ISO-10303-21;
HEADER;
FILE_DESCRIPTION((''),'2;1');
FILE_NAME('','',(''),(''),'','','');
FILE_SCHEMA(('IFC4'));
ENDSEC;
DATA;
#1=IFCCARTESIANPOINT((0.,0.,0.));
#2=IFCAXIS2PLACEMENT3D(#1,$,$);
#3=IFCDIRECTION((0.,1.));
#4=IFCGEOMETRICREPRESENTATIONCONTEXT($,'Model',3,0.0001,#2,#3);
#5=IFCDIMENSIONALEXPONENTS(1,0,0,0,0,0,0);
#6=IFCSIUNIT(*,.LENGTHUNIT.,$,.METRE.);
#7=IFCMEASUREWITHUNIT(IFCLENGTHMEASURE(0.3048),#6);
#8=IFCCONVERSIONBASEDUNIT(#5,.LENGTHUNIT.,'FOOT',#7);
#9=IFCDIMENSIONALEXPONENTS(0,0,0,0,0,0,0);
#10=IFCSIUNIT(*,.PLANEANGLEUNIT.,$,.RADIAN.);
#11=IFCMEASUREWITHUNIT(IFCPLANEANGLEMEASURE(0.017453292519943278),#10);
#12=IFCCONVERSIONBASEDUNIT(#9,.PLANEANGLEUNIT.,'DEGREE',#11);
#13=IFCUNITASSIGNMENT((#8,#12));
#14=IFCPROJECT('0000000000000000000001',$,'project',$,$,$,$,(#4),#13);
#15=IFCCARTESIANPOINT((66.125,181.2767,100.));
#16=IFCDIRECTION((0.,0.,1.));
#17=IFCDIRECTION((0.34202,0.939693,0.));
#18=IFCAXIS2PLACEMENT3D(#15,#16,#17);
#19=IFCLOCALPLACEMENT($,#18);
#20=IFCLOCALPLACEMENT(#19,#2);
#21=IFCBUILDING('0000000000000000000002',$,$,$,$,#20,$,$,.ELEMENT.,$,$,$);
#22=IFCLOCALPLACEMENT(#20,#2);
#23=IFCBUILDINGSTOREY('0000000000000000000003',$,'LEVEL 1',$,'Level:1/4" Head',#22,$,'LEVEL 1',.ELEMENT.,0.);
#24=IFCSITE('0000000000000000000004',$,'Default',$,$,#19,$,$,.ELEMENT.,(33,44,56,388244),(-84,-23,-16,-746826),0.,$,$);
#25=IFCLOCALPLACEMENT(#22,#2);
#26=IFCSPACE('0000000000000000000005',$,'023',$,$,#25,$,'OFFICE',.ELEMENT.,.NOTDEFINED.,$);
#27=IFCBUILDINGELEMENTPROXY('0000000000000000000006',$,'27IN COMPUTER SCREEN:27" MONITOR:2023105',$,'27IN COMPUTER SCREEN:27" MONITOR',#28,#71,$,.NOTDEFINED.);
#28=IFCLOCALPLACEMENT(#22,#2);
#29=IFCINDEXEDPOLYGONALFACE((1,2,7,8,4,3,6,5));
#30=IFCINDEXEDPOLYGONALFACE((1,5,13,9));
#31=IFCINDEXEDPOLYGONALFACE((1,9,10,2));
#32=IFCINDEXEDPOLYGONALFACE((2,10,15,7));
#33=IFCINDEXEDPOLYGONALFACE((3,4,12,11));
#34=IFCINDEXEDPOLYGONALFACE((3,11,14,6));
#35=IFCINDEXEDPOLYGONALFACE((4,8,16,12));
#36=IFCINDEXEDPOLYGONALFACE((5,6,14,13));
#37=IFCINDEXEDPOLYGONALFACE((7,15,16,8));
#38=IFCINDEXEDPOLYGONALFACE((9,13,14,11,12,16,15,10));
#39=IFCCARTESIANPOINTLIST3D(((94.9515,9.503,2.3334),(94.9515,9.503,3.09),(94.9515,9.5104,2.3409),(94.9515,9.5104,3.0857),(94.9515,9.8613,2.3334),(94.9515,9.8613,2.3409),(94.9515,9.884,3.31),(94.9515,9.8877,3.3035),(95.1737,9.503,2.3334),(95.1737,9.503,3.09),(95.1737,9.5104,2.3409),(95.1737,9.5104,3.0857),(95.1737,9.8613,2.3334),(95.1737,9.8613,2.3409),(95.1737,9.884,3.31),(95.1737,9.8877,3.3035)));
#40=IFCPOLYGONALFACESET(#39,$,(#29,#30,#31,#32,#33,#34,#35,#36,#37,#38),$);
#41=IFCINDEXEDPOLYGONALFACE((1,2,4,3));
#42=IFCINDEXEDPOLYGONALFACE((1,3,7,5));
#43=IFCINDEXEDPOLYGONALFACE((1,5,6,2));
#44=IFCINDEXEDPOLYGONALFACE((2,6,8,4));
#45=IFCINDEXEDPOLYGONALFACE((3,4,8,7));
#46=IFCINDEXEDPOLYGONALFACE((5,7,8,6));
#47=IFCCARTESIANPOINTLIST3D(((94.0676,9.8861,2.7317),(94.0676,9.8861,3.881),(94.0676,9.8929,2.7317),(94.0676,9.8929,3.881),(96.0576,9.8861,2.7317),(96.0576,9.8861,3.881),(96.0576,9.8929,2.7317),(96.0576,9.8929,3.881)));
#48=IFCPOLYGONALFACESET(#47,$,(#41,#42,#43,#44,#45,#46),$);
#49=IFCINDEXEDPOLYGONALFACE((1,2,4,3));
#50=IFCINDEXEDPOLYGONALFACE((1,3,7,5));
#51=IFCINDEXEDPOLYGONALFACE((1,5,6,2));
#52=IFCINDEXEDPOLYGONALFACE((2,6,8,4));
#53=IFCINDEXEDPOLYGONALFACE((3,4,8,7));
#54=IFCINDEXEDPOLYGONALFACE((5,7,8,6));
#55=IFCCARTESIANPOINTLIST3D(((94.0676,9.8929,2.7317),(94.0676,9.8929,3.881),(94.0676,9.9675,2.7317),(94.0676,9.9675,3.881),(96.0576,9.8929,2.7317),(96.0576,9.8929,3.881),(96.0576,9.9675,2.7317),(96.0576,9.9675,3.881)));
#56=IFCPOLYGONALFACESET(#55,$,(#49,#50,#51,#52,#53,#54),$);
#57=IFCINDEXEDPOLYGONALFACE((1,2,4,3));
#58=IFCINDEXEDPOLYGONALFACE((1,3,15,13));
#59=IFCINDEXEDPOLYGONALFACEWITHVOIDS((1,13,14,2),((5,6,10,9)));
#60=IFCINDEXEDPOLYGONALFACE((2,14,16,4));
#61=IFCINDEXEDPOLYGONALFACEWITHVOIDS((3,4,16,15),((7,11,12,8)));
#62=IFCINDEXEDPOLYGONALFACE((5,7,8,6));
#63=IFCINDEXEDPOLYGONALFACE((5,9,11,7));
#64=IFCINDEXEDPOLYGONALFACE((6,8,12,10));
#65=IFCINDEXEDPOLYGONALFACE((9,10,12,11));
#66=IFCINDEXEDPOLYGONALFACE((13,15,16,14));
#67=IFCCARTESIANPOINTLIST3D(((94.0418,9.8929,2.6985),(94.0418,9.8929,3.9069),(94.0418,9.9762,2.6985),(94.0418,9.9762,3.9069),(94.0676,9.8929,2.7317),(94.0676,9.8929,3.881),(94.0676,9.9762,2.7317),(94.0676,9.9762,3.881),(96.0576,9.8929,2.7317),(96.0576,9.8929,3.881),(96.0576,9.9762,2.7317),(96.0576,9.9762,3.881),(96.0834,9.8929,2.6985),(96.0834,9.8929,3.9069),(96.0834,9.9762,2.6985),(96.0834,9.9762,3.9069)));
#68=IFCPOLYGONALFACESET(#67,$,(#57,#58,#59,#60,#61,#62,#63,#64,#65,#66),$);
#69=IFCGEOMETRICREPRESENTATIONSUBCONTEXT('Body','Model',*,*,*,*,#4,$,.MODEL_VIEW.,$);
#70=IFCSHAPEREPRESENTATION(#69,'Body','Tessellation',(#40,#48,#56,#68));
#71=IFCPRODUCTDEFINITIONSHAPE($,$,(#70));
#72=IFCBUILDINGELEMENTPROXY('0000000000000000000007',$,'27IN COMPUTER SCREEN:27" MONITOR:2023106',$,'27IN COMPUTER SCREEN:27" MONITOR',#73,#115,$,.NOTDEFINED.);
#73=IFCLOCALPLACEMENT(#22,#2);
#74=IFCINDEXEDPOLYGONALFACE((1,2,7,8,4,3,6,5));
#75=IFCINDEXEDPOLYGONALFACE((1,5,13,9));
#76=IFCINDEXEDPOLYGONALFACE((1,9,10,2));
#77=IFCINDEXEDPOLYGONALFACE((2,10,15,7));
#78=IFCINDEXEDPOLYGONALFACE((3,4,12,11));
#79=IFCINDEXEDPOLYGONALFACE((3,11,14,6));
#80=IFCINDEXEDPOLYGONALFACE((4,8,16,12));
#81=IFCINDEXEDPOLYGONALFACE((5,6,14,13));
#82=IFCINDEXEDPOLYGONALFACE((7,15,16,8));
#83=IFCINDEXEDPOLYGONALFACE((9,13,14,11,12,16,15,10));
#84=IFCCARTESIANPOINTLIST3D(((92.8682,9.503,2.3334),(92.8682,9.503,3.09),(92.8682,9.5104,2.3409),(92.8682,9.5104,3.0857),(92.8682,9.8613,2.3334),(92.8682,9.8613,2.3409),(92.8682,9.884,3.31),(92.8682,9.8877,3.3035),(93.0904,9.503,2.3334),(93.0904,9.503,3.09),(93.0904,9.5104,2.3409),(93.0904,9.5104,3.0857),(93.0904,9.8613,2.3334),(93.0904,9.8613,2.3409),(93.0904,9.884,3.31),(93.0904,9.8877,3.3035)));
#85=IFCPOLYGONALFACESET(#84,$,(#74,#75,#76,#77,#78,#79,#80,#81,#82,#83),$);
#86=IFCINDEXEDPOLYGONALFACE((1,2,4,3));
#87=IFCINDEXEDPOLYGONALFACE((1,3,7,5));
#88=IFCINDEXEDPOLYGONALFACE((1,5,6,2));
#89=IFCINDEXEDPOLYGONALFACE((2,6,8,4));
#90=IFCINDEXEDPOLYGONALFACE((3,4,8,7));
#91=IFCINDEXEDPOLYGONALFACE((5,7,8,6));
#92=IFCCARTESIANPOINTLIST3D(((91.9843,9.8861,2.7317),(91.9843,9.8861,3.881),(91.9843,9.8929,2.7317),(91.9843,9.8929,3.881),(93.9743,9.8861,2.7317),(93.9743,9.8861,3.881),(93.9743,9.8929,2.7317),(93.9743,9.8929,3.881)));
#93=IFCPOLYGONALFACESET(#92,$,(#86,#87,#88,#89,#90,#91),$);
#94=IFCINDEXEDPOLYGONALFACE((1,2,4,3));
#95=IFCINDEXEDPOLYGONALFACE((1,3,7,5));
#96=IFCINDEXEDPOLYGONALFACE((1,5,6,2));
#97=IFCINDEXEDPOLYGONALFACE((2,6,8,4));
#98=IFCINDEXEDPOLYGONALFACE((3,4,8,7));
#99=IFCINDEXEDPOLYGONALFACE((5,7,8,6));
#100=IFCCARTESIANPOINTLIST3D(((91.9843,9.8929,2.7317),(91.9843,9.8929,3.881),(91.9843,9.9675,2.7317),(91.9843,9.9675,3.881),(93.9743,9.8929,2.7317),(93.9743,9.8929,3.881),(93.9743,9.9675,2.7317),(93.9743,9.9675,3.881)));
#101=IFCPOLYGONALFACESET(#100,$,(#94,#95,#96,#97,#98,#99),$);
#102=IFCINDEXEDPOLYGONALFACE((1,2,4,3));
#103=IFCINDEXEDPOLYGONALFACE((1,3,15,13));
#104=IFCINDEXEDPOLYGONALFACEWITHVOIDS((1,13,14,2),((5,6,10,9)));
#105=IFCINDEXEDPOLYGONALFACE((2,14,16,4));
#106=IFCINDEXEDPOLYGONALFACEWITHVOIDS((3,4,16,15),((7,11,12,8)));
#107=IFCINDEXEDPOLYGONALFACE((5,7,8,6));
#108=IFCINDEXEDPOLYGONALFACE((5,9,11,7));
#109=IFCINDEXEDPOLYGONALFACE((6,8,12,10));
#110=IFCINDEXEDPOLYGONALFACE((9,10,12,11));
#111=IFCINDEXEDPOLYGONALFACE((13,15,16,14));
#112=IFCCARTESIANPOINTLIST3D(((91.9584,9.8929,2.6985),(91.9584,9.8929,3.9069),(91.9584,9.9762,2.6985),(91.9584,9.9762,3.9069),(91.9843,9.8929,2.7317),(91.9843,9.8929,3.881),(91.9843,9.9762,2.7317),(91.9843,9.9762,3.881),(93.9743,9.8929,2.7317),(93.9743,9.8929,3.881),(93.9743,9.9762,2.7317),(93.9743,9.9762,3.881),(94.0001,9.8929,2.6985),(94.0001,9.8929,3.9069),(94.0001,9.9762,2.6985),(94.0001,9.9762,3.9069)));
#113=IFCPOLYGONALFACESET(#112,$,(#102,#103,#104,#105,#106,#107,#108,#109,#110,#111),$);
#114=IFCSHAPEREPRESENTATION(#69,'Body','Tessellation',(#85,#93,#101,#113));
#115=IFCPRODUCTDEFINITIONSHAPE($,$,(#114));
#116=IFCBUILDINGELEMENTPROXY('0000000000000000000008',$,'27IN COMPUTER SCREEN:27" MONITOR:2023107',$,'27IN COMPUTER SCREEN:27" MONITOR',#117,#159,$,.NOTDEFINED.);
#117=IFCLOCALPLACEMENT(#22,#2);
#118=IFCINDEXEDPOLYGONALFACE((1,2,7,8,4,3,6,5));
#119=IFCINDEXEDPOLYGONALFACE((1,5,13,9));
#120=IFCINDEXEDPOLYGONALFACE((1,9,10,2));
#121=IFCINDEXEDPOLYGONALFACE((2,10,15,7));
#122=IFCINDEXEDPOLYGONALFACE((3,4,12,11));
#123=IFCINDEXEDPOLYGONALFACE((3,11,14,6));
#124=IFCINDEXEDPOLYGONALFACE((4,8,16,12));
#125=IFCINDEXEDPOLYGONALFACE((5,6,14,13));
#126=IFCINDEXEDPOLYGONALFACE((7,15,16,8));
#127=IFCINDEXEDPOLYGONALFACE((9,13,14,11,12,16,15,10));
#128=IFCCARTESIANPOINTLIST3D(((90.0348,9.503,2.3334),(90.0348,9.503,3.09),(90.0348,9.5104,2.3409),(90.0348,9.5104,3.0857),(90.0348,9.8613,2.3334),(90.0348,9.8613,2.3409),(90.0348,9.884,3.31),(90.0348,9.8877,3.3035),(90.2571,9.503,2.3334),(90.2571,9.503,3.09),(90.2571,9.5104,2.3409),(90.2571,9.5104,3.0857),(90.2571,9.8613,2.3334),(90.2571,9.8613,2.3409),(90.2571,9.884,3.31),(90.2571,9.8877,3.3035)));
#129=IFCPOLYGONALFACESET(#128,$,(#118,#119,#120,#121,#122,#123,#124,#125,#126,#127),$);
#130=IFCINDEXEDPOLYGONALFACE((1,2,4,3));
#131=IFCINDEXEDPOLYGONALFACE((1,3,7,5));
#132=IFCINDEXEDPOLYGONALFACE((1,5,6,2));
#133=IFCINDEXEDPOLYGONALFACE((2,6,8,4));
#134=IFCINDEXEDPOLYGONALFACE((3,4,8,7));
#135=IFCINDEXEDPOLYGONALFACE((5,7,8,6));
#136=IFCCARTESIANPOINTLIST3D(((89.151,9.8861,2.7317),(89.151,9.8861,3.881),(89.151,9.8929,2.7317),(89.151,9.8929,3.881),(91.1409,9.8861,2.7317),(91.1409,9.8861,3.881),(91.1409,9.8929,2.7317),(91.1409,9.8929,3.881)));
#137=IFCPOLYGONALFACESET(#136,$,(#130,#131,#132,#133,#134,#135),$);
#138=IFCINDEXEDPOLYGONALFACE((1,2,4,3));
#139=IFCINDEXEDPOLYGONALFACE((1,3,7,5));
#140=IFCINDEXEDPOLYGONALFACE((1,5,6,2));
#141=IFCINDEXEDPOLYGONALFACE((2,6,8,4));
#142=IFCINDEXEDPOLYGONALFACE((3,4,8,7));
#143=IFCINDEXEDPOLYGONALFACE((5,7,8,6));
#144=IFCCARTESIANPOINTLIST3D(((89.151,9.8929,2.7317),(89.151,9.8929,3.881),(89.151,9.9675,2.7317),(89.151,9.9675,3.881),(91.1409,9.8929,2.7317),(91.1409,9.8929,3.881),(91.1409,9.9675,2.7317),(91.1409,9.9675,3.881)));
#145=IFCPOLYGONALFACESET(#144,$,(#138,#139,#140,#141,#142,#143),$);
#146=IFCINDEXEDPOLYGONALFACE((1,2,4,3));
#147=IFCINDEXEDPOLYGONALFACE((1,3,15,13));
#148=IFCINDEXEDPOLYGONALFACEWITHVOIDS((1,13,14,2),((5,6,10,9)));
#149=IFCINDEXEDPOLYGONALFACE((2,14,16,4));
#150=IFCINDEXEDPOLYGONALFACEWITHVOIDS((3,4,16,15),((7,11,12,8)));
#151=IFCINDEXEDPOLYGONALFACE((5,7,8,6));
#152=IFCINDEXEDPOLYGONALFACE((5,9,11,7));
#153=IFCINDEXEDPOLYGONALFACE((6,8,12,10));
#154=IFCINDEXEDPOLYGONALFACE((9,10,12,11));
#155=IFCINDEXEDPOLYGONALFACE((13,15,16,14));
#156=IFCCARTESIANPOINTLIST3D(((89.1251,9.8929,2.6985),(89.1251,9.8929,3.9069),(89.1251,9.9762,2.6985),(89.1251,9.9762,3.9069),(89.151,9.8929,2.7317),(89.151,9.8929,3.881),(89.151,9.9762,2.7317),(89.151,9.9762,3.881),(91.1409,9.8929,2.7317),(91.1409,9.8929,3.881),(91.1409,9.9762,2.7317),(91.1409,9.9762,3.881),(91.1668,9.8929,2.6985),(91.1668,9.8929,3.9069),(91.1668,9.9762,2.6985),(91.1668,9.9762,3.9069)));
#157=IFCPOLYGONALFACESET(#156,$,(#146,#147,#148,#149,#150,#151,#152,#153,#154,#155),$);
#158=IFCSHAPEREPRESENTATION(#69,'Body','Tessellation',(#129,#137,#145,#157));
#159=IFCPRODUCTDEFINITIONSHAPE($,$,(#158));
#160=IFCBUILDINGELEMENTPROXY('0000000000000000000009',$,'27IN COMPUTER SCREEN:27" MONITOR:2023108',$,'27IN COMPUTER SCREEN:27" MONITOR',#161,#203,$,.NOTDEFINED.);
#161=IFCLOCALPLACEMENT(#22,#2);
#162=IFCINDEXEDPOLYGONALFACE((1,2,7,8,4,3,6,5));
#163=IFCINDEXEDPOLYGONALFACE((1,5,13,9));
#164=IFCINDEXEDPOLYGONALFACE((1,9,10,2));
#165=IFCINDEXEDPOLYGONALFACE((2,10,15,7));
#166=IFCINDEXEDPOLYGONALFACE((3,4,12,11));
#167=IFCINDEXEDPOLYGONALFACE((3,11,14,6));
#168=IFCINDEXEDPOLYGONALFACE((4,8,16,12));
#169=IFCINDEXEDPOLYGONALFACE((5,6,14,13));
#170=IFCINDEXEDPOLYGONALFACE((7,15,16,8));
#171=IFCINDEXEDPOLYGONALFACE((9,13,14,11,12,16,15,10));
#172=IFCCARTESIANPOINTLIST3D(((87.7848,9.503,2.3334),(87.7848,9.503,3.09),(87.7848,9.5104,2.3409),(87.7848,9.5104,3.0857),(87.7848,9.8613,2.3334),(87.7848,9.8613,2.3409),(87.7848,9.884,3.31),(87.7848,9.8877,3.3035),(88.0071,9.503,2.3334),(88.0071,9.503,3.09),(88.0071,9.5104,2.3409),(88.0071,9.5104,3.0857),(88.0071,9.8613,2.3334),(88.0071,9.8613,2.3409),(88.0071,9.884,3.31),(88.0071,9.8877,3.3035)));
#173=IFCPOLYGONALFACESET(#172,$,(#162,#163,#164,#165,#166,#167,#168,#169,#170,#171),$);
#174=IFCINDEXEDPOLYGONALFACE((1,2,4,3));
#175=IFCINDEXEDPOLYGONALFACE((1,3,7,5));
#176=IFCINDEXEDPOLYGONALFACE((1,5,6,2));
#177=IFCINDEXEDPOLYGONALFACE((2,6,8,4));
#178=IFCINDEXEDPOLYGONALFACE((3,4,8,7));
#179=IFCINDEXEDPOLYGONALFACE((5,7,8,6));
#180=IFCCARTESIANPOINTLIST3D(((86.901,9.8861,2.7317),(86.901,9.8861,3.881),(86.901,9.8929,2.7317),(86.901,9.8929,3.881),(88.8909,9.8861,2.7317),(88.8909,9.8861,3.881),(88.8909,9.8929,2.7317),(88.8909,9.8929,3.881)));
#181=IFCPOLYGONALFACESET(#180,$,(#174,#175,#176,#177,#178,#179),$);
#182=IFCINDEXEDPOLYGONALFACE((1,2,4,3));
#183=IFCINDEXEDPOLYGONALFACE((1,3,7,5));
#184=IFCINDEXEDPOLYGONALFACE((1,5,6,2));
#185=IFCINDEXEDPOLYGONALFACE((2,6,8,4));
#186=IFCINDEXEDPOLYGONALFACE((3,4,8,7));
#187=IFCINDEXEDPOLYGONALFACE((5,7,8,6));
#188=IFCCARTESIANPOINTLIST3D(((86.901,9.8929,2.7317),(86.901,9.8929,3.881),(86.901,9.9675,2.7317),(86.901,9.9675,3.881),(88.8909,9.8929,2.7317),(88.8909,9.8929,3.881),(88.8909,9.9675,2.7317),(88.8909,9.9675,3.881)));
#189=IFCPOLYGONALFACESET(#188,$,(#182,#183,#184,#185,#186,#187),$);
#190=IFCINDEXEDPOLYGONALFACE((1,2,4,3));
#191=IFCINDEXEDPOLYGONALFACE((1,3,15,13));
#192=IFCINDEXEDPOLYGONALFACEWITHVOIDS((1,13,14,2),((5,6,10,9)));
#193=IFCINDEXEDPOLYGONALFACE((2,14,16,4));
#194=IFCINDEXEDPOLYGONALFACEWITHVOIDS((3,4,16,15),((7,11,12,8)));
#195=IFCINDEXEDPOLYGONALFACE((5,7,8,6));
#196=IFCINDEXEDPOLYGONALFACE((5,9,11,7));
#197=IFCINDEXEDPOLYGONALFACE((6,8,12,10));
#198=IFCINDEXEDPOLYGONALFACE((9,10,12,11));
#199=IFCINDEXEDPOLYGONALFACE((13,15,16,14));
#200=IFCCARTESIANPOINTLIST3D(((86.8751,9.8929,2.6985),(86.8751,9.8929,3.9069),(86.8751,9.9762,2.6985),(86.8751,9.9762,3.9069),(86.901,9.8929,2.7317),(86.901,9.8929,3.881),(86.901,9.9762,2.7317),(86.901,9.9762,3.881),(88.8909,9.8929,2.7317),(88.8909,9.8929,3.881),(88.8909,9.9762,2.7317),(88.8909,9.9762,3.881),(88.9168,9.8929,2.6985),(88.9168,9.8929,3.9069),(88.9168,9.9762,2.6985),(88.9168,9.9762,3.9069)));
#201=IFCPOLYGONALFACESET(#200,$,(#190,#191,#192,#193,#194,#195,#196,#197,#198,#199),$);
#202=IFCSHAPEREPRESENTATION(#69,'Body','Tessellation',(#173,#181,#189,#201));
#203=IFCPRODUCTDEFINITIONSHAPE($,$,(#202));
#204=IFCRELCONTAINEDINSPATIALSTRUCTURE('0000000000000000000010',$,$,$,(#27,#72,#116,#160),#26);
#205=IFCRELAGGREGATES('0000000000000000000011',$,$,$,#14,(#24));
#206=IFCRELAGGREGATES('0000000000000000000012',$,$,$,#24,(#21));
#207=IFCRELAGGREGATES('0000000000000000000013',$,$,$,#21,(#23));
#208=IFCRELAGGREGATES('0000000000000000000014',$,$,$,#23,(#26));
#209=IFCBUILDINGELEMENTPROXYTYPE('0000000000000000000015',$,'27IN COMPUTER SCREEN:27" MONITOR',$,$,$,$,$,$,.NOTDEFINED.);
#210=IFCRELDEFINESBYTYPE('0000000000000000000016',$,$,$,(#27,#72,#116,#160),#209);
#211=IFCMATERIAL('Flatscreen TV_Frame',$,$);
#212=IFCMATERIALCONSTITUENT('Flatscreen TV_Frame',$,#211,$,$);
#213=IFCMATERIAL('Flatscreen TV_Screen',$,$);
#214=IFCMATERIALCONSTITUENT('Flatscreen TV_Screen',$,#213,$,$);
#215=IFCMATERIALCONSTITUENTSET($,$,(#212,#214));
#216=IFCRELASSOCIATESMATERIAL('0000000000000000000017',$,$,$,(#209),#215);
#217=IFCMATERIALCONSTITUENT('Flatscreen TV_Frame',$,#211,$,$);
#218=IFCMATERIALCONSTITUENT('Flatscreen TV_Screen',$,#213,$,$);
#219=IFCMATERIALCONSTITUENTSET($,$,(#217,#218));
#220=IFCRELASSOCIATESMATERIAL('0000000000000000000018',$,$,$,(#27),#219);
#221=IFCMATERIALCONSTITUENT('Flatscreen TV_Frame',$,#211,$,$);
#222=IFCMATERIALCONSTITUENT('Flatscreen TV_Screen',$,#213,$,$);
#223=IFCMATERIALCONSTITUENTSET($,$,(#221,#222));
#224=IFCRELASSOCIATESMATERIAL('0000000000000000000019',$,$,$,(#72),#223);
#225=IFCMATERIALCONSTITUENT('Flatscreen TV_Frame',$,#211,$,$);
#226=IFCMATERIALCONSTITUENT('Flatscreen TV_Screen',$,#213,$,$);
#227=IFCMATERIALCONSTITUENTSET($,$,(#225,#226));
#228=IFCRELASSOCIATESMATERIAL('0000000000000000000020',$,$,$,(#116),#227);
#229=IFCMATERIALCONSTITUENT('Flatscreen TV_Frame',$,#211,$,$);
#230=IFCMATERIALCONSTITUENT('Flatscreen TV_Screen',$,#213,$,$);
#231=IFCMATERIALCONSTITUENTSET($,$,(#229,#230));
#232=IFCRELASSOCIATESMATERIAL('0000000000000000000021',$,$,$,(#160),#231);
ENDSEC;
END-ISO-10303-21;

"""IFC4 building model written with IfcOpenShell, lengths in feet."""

from ifc_helpers import new_model, entity, si_unit, converted_unit, direction, frame, frame_2d, origin, origin_2d_with_axis, place, context, subcontext, project, spatial, polyline, rectangle, outline, extrude, source, transform, mapped, material, constituent, constituent_set, type_object, type_shapes, element, save


model = new_model("IFC4")

# Units and contexts
model_context = context("Model", 3, precision=0.0001, world=origin(), true_north=direction((0.0, 1.0)))
body_context = subcontext(model_context, "Body", "Model", "MODEL_VIEW")
ifc_project = project(units=[converted_unit("LENGTHUNIT", "FOOT", entity("IfcLengthMeasure", 0.3048), si_unit("LENGTHUNIT", "METRE"), dimensions=[1, 0, 0, 0, 0, 0, 0]), converted_unit("PLANEANGLEUNIT", "DEGREE", entity("IfcPlaneAngleMeasure", 0.017453292519943278), si_unit("PLANEANGLEUNIT", "RADIAN"), dimensions=[0, 0, 0, 0, 0, 0, 0])], contexts=[model_context])

# Site, building, storey
site_placement = place(None, frame((66.125, 181.2767, 100.0), z_axis=(0.0, 0.0, 1.0), x_axis=(0.34202, 0.939693, 0.0)))
site = spatial("IfcSite", under=ifc_project, at=site_placement, Name="Default", CompositionType="ELEMENT", RefLatitude=(33, 44, 56, 388244), RefLongitude=(-84, -23, -16, -746826), RefElevation=0.0)
building_placement = place(site_placement, origin())
building = spatial("IfcBuilding", under=site, at=building_placement, CompositionType="ELEMENT")
storey_placement = place(building_placement, origin())
storey = spatial("IfcBuildingStorey", under=building, at=storey_placement, Name="LEVEL 1", ObjectType="Level:1/4\" Head", LongName="LEVEL 1", CompositionType="ELEMENT", Elevation=0.0)

# Shared definitions
space_1_placement = place(storey_placement, origin())
space_1 = spatial("IfcSpace", under=storey, at=space_1_placement, Name="023", LongName="OFFICE", CompositionType="ELEMENT", PredefinedType="NOTDEFINED")

# Building element proxies
ifc_material_1 = material(Name="Flatscreen TV_Frame")
ifc_constituent_1 = constituent(ifc_material_1, Name="Flatscreen TV_Frame")
ifc_material_2 = material(Name="Flatscreen TV_Screen")
ifc_constituent_2 = constituent(ifc_material_2, Name="Flatscreen TV_Screen")
ifc_constituent_set_1 = constituent_set(constituents=[ifc_constituent_1, ifc_constituent_2])
ifc_constituent_3 = constituent(ifc_material_1, Name="Flatscreen TV_Frame")
ifc_constituent_4 = constituent(ifc_material_2, Name="Flatscreen TV_Screen")
ifc_constituent_set_2 = constituent_set(constituents=[ifc_constituent_3, ifc_constituent_4])
building_element_proxy_type_1 = type_object("IfcBuildingElementProxyType", Name="27IN COMPUTER SCREEN:27\" MONITOR", PredefinedType="NOTDEFINED", material=ifc_constituent_set_2)
shared_shape_1 = source(origin(), body_context, "Body", "SweptSolid", [
    extrude(outline(polyline([(-0.4392, -0.3657), (-0.4392, -0.3731), (0.0007, -0.3731), (0.379, 0.2821), (0.0686, 0.4613), (0.0649, 0.4548), (0.3688, 0.2794), (-0.0036, -0.3657), (-0.4392, -0.3657)])), frame((-0.1111, -0.0264, 0.0687), z_axis=(-1.0, 0.0, 0.0), x_axis=(0.0, 0.866025, -0.5)), (0.0, 0.0, -1.0), 0.2222),
    extrude(rectangle(XDim=0.0068, YDim=1.9899, at=origin_2d_with_axis()), frame((0.0, -0.2257, 0.0331), z_axis=(0.0, 0.0, 1.0), x_axis=(0.0, 1.0, 0.0)), (0.0, 0.0, 1.0), 1.1493),
    extrude(rectangle(XDim=0.0746, YDim=1.9899, at=frame_2d((0.0, 0.0), x_axis=(1.0, 0.0))), frame((0.0, -0.2664, 0.0331), z_axis=(0.0, 0.0, 1.0), x_axis=(0.0, 1.0, 0.0)), (0.0, 0.0, 1.0), 1.1493),
    extrude(outline(polyline([(-0.6042, -1.0208), (0.6042, -1.0208), (0.6042, 1.0208), (-0.6042, 1.0208), (-0.6042, -1.0208)]), holes=[polyline([(-0.5783, -0.995), (-0.5783, 0.995), (0.571, 0.995), (0.571, -0.995), (-0.5783, -0.995)])]), frame((0.0, -0.3125, 0.6042), z_axis=(0.0, 1.0, 0.0), x_axis=(0.0, 0.0, -1.0)), (0.0, 0.0, 1.0), 0.0833),
])
type_shapes(building_element_proxy_type_1, [shared_shape_1])
proxy_1_placement = place(space_1_placement, frame((95.0626, 9.6637, 2.6985), z_axis=(0.0, 0.0, 1.0), x_axis=(-1.0, 0.0, 0.0)))
element("IfcBuildingElementProxy", 1, at=proxy_1_placement, inside=space_1, type_object=building_element_proxy_type_1, material=ifc_constituent_set_1, Name="27IN COMPUTER SCREEN:27\" MONITOR:2023105", ObjectType="27IN COMPUTER SCREEN:27\" MONITOR", PredefinedType="NOTDEFINED", context=body_context, shape_type="MappedRepresentation", body=[
    mapped(shared_shape_1, transform((0.0, 0.0, 0.0), scale=1.0)),
])
ifc_constituent_5 = constituent(ifc_material_1, Name="Flatscreen TV_Frame")
ifc_constituent_6 = constituent(ifc_material_2, Name="Flatscreen TV_Screen")
ifc_constituent_set_3 = constituent_set(constituents=[ifc_constituent_5, ifc_constituent_6])
proxy_2_placement = place(space_1_placement, frame((92.9793, 9.6637, 2.6985), z_axis=(0.0, 0.0, 1.0), x_axis=(-1.0, 0.0, 0.0)))
element("IfcBuildingElementProxy", 2, at=proxy_2_placement, inside=space_1, type_object=building_element_proxy_type_1, material=ifc_constituent_set_3, Name="27IN COMPUTER SCREEN:27\" MONITOR:2023106", ObjectType="27IN COMPUTER SCREEN:27\" MONITOR", PredefinedType="NOTDEFINED", context=body_context, shape_type="MappedRepresentation", body=[
    mapped(shared_shape_1, transform((0.0, 0.0, 0.0), scale=1.0)),
])
ifc_constituent_7 = constituent(ifc_material_1, Name="Flatscreen TV_Frame")
ifc_constituent_8 = constituent(ifc_material_2, Name="Flatscreen TV_Screen")
ifc_constituent_set_4 = constituent_set(constituents=[ifc_constituent_7, ifc_constituent_8])
proxy_3_placement = place(space_1_placement, frame((90.1459, 9.6637, 2.6985), z_axis=(0.0, 0.0, 1.0), x_axis=(-1.0, 0.0, 0.0)))
element("IfcBuildingElementProxy", 3, at=proxy_3_placement, inside=space_1, type_object=building_element_proxy_type_1, material=ifc_constituent_set_4, Name="27IN COMPUTER SCREEN:27\" MONITOR:2023107", ObjectType="27IN COMPUTER SCREEN:27\" MONITOR", PredefinedType="NOTDEFINED", context=body_context, shape_type="MappedRepresentation", body=[
    mapped(shared_shape_1, transform((0.0, 0.0, 0.0), scale=1.0)),
])
ifc_constituent_9 = constituent(ifc_material_1, Name="Flatscreen TV_Frame")
ifc_constituent_10 = constituent(ifc_material_2, Name="Flatscreen TV_Screen")
ifc_constituent_set_5 = constituent_set(constituents=[ifc_constituent_9, ifc_constituent_10])
proxy_4_placement = place(space_1_placement, frame((87.8959, 9.6637, 2.6985), z_axis=(0.0, 0.0, 1.0), x_axis=(-1.0, 0.0, 0.0)))
element("IfcBuildingElementProxy", 4, at=proxy_4_placement, inside=space_1, type_object=building_element_proxy_type_1, material=ifc_constituent_set_5, Name="27IN COMPUTER SCREEN:27\" MONITOR:2023108", ObjectType="27IN COMPUTER SCREEN:27\" MONITOR", PredefinedType="NOTDEFINED", context=body_context, shape_type="MappedRepresentation", body=[
    mapped(shared_shape_1, transform((0.0, 0.0, 0.0), scale=1.0)),
])

save(model, "model.ifc")
